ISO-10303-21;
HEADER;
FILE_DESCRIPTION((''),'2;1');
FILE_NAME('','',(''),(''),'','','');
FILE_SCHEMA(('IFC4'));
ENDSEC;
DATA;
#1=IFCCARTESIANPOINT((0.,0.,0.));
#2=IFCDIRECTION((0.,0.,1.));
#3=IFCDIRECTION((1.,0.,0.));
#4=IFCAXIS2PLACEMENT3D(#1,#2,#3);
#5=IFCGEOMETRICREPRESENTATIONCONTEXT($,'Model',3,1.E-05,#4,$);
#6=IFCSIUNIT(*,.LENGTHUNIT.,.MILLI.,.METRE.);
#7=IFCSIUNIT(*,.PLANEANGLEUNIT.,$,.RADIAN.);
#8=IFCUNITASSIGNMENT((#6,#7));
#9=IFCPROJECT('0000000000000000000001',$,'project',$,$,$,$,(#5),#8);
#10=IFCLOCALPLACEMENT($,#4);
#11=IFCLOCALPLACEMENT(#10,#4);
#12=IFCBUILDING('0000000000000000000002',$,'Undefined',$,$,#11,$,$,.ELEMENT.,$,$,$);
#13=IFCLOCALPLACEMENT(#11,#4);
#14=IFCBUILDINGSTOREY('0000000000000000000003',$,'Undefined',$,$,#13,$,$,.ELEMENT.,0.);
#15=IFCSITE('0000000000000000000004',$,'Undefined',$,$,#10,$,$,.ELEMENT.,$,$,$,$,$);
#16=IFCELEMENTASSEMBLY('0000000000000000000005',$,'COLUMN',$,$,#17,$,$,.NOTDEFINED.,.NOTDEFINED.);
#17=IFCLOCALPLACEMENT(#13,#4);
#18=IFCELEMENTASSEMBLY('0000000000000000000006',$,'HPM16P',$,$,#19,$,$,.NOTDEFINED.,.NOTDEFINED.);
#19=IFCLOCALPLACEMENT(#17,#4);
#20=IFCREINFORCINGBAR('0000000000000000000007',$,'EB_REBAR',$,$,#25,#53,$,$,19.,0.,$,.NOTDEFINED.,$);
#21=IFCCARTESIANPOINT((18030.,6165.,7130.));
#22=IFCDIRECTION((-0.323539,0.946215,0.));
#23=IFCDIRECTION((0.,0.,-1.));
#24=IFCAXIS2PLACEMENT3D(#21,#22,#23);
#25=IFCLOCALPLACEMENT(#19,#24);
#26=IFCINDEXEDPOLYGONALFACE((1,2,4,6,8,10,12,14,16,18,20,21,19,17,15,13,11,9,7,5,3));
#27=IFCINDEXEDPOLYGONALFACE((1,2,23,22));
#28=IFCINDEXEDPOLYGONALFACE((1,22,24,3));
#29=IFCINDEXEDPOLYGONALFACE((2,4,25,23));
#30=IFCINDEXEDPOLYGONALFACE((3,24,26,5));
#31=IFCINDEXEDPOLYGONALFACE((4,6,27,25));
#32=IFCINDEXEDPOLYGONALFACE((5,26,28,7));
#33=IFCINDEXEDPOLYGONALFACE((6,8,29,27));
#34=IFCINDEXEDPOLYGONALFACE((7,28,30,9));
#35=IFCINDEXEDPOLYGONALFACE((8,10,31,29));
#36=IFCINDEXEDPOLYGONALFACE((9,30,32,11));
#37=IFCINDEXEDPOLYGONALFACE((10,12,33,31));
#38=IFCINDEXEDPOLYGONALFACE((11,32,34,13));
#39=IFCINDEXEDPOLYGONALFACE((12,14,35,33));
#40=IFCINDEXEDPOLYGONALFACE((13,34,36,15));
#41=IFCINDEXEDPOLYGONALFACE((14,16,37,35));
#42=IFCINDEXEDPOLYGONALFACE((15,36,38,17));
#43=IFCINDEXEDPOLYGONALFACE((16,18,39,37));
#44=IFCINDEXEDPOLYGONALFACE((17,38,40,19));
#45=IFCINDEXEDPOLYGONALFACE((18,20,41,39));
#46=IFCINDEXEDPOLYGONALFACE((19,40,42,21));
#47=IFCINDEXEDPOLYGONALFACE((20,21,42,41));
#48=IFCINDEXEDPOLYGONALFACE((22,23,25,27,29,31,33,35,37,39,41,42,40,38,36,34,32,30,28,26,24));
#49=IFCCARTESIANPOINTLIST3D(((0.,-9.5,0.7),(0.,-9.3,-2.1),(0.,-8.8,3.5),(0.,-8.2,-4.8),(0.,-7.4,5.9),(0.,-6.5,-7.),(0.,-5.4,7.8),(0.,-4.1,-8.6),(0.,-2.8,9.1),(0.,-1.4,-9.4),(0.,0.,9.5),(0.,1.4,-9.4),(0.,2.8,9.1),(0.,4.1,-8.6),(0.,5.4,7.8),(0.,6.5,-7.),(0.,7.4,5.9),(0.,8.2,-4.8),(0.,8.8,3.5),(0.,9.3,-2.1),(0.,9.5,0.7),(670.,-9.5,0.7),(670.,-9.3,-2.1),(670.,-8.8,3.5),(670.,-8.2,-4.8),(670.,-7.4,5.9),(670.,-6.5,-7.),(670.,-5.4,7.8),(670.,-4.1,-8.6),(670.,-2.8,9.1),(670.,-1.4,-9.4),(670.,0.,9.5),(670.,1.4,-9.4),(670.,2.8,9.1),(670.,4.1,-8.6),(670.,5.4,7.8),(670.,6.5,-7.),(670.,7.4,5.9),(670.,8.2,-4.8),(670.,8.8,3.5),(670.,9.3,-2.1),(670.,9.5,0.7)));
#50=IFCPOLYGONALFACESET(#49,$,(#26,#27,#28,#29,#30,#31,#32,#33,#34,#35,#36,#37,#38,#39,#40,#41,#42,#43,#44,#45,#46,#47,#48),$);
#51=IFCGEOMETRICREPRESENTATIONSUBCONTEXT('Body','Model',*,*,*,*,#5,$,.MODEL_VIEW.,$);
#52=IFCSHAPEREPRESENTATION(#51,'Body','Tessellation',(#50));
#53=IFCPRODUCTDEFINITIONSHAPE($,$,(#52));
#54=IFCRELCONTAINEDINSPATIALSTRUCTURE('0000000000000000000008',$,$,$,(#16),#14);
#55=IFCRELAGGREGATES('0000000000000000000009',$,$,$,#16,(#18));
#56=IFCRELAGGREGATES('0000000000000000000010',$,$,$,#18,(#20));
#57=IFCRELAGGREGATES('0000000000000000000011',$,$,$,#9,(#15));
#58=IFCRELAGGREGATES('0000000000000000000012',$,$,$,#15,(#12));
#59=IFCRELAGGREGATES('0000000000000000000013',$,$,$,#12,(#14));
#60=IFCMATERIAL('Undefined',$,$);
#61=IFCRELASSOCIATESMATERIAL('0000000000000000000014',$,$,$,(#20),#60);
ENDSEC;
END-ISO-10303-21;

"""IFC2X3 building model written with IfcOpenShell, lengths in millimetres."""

from ifc_helpers import new_model, entity, si_unit, frame, origin_with_axes, place, context, subcontext, project, spatial, source, transform, mapped, material, element, aggregate, save


model = new_model("IFC2X3")

# Units and contexts
model_context = context("Model", 3, precision=1e-05, world=origin_with_axes())
body_context = subcontext(model_context, "Body", "Model", "MODEL_VIEW")
ifc_project = project(units=[si_unit("LENGTHUNIT", "METRE", prefix="MILLI"), si_unit("PLANEANGLEUNIT", "RADIAN")], contexts=[model_context])

# Site, building, storey
site_placement = place(None, origin_with_axes())
site = spatial("IfcSite", under=ifc_project, at=site_placement, Name="Undefined", CompositionType="ELEMENT")
building_placement = place(site_placement, origin_with_axes())
building = spatial("IfcBuilding", under=site, at=building_placement, Name="Undefined", CompositionType="ELEMENT")
storey_placement = place(building_placement, origin_with_axes())
storey = spatial("IfcBuildingStorey", under=building, at=storey_placement, Name="Undefined", CompositionType="ELEMENT", Elevation=0.0)

# Element assemblies
assembly_1_placement = place(storey_placement, origin_with_axes())
assembly_1 = element("IfcElementAssembly", 1, at=assembly_1_placement, inside=storey, Name="COLUMN", AssemblyPlace="NOTDEFINED", PredefinedType="NOTDEFINED")
assembly_2_placement = place(assembly_1_placement, origin_with_axes())
assembly_2 = element("IfcElementAssembly", 2, at=assembly_2_placement, Name="HPM16P", AssemblyPlace="NOTDEFINED", PredefinedType="NOTDEFINED")

aggregate(assembly_1, [assembly_2])

# Shared definitions
ifc_material_1 = material(Name="Undefined")

# Reinforcing bar
shared_shape_1 = source(origin_with_axes(), body_context, "Body", "AdvancedSweptSolid", [
    entity("IfcSweptDiskSolid", entity("IfcTrimmedCurve", entity("IfcLine", entity("IfcCartesianPoint", [0.0, 0.0, 0.0]), entity("IfcVector", entity("IfcDirection", [1.0, 0.0, 0.0]), 1.0)), [entity("IfcParameterValue", 0.0)], [entity("IfcParameterValue", 670.0)], True, "PARAMETER"), 9.5, None, 0.0, 670.0),
])
reinforcing_bar_1_placement = place(assembly_2_placement, frame((18030.0, 6165.0, 7130.0), z_axis=(-0.323539, 0.946215, 0.0), x_axis=(0.0, 0.0, -1.0)))
reinforcing_bar_1 = element("IfcReinforcingBar", 3, at=reinforcing_bar_1_placement, material=ifc_material_1, Name="EB_REBAR", BarRole="NOTDEFINED", CrossSectionArea=0.0, NominalDiameter=19.0, context=body_context, shape_type="MappedRepresentation", body=[
    mapped(shared_shape_1, transform((0.0, 0.0, 0.0))),
])
aggregate(assembly_2, [reinforcing_bar_1])

save(model, "model.ifc")
